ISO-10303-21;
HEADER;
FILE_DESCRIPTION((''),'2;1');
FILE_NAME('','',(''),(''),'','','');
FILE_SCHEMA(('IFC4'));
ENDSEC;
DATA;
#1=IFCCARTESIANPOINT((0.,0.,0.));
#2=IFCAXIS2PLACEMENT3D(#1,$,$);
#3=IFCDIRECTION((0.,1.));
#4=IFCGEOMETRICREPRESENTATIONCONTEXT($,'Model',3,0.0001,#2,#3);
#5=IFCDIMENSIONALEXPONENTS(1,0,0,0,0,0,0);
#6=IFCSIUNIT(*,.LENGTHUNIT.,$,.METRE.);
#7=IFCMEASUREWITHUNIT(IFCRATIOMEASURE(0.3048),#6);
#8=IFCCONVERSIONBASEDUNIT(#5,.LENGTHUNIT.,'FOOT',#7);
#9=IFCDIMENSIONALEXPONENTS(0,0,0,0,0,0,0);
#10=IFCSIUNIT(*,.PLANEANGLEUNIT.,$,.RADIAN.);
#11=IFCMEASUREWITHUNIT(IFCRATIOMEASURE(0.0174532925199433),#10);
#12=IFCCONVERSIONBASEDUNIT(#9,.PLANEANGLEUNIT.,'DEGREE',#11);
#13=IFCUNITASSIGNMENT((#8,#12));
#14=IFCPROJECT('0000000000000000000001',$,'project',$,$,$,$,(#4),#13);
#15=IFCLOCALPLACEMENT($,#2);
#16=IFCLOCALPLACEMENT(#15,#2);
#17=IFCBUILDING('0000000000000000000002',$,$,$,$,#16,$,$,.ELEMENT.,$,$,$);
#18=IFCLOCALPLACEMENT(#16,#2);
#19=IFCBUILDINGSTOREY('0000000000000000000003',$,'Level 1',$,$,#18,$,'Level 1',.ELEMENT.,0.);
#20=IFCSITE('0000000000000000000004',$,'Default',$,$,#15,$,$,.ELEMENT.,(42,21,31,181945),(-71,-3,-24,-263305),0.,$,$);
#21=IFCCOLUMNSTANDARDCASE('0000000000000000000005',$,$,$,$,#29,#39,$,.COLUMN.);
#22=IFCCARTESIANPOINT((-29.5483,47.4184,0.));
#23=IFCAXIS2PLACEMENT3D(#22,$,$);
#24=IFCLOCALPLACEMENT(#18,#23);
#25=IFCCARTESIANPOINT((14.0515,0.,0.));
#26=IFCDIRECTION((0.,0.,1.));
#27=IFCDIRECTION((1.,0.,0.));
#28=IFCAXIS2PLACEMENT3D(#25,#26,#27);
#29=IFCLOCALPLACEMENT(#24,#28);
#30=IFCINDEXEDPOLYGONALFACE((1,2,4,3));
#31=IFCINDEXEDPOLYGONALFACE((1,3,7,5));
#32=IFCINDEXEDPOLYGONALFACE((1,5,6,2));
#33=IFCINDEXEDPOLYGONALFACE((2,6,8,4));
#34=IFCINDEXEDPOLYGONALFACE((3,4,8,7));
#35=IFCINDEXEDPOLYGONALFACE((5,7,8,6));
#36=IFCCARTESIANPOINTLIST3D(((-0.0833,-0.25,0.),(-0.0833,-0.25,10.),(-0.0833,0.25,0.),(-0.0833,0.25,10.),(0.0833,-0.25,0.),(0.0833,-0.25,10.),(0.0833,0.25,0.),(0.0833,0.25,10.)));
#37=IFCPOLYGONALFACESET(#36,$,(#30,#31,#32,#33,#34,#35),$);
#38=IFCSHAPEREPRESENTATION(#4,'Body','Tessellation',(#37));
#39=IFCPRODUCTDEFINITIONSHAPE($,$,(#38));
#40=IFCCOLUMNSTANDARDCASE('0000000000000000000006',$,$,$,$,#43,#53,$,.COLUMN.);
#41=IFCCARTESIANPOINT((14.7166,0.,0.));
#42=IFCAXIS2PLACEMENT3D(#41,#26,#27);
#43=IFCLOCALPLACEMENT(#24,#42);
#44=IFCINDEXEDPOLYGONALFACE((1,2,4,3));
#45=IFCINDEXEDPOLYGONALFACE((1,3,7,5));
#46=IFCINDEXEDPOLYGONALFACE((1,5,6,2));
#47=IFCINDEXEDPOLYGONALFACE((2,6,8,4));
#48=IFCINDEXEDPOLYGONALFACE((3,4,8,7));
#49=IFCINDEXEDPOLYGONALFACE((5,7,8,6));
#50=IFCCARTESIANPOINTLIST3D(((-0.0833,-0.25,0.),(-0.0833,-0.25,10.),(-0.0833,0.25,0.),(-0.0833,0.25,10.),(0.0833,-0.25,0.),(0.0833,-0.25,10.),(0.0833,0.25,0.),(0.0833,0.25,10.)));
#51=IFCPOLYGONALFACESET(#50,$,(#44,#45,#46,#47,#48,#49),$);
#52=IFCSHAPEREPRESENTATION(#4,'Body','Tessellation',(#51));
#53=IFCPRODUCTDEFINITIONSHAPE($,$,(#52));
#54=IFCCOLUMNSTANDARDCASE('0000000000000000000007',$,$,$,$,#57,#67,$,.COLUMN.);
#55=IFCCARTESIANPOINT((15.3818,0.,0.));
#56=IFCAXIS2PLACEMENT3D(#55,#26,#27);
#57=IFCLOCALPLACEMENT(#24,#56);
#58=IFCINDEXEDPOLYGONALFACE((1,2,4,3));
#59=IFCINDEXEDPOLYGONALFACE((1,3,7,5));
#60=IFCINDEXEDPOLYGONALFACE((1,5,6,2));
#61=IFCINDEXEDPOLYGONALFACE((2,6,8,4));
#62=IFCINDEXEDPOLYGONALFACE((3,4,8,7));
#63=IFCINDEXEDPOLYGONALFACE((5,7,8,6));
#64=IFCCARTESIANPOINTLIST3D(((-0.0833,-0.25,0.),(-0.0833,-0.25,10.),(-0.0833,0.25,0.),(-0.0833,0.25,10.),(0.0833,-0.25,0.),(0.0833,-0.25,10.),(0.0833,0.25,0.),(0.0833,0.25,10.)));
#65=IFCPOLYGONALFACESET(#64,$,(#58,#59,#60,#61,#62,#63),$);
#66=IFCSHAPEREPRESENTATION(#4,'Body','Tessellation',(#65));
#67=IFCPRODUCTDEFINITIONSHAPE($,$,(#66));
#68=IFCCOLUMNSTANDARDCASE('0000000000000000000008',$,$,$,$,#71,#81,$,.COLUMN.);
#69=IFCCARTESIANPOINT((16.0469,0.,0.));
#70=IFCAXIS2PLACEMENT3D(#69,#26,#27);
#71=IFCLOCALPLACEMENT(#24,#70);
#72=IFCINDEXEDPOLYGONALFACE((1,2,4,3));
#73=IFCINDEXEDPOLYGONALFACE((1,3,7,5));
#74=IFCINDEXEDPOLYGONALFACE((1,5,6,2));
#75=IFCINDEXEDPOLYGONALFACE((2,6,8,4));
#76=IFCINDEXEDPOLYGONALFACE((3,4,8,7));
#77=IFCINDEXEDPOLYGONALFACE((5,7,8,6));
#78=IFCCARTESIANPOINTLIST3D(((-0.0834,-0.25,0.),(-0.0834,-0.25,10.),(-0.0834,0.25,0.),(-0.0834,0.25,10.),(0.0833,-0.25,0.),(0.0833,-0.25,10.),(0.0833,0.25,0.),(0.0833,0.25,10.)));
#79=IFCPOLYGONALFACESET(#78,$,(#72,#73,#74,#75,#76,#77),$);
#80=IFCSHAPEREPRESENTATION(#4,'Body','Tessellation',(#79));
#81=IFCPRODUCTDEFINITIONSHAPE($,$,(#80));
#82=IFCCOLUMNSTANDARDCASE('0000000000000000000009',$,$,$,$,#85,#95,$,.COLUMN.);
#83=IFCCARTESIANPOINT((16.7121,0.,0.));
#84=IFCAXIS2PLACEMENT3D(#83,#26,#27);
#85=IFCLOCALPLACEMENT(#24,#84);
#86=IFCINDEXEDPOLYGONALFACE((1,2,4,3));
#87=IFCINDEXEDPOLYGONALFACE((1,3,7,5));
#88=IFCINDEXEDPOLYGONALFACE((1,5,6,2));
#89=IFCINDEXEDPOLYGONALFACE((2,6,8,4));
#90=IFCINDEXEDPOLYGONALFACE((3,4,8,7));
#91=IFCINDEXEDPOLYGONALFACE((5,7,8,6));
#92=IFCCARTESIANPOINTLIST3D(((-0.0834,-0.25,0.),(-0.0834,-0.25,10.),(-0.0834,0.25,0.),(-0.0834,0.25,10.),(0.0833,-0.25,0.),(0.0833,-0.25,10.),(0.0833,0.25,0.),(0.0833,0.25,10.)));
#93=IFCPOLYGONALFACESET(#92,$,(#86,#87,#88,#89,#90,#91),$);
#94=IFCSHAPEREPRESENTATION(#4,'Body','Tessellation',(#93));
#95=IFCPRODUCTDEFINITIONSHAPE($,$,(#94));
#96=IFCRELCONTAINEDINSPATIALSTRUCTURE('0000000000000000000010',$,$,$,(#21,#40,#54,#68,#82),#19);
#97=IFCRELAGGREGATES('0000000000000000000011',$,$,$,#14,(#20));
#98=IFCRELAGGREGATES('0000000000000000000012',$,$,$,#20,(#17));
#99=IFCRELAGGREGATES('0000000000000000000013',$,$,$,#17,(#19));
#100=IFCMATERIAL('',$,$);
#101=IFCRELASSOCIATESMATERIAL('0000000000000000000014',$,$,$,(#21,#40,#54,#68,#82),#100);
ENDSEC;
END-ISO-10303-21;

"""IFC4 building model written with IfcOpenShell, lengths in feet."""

from ifc_helpers import new_model, entity, si_unit, converted_unit, direction, frame, origin, place, context, project, spatial, rectangle, extrude, material, element, save


model = new_model("IFC4")

# Units and contexts
model_context = context("Model", 3, precision=0.0001, world=origin(), true_north=direction((0.0, 1.0)))
ifc_project = project(units=[converted_unit("LENGTHUNIT", "FOOT", entity("IfcRatioMeasure", 0.3048), si_unit("LENGTHUNIT", "METRE"), dimensions=[1, 0, 0, 0, 0, 0, 0]), converted_unit("PLANEANGLEUNIT", "DEGREE", entity("IfcRatioMeasure", 0.0174532925199433), si_unit("PLANEANGLEUNIT", "RADIAN"), dimensions=[0, 0, 0, 0, 0, 0, 0])], contexts=[model_context])

# Site, building, storey
site_placement = place(None, origin())
site = spatial("IfcSite", under=ifc_project, at=site_placement, Name="Default", CompositionType="ELEMENT", RefLatitude=(42, 21, 31, 181945), RefLongitude=(-71, -3, -24, -263305), RefElevation=0.0)
building_placement = place(site_placement, origin())
building = spatial("IfcBuilding", under=site, at=building_placement, CompositionType="ELEMENT")
storey_placement = place(building_placement, origin())
storey = spatial("IfcBuildingStorey", under=building, at=storey_placement, Name="Level 1", LongName="Level 1", CompositionType="ELEMENT", Elevation=0.0)

# Columns
ifc_material = material(Name="")
placement = place(storey_placement, frame((-29.5483, 47.4184, 0.0)))
for number, where, z_axis, x_axis in (
    (1, (14.0515, 0.0, 0.0), (0.0, 0.0, 1.0), (1.0, 0.0, 0.0)),
    (2, (14.7166, 0.0, 0.0), (0.0, 0.0, 1.0), (1.0, 0.0, 0.0)),
    (3, (15.3818, 0.0, 0.0), (0.0, 0.0, 1.0), (1.0, 0.0, 0.0)),
    (4, (16.0469, 0.0, 0.0), (0.0, 0.0, 1.0), (1.0, 0.0, 0.0)),
    (5, (16.7121, 0.0, 0.0), (0.0, 0.0, 1.0), (1.0, 0.0, 0.0)),
):
    element("IfcColumnStandardCase", number, at=place(placement, frame(where, z_axis=z_axis, x_axis=x_axis)), inside=storey, material=ifc_material, PredefinedType="COLUMN", context=model_context, shape_type="SweptSolid", body=[
        extrude(rectangle(XDim=0.1667, YDim=0.5), origin(), (0.0, 0.0, 1.0), 10.0),
    ])

save(model, "model.ifc")
